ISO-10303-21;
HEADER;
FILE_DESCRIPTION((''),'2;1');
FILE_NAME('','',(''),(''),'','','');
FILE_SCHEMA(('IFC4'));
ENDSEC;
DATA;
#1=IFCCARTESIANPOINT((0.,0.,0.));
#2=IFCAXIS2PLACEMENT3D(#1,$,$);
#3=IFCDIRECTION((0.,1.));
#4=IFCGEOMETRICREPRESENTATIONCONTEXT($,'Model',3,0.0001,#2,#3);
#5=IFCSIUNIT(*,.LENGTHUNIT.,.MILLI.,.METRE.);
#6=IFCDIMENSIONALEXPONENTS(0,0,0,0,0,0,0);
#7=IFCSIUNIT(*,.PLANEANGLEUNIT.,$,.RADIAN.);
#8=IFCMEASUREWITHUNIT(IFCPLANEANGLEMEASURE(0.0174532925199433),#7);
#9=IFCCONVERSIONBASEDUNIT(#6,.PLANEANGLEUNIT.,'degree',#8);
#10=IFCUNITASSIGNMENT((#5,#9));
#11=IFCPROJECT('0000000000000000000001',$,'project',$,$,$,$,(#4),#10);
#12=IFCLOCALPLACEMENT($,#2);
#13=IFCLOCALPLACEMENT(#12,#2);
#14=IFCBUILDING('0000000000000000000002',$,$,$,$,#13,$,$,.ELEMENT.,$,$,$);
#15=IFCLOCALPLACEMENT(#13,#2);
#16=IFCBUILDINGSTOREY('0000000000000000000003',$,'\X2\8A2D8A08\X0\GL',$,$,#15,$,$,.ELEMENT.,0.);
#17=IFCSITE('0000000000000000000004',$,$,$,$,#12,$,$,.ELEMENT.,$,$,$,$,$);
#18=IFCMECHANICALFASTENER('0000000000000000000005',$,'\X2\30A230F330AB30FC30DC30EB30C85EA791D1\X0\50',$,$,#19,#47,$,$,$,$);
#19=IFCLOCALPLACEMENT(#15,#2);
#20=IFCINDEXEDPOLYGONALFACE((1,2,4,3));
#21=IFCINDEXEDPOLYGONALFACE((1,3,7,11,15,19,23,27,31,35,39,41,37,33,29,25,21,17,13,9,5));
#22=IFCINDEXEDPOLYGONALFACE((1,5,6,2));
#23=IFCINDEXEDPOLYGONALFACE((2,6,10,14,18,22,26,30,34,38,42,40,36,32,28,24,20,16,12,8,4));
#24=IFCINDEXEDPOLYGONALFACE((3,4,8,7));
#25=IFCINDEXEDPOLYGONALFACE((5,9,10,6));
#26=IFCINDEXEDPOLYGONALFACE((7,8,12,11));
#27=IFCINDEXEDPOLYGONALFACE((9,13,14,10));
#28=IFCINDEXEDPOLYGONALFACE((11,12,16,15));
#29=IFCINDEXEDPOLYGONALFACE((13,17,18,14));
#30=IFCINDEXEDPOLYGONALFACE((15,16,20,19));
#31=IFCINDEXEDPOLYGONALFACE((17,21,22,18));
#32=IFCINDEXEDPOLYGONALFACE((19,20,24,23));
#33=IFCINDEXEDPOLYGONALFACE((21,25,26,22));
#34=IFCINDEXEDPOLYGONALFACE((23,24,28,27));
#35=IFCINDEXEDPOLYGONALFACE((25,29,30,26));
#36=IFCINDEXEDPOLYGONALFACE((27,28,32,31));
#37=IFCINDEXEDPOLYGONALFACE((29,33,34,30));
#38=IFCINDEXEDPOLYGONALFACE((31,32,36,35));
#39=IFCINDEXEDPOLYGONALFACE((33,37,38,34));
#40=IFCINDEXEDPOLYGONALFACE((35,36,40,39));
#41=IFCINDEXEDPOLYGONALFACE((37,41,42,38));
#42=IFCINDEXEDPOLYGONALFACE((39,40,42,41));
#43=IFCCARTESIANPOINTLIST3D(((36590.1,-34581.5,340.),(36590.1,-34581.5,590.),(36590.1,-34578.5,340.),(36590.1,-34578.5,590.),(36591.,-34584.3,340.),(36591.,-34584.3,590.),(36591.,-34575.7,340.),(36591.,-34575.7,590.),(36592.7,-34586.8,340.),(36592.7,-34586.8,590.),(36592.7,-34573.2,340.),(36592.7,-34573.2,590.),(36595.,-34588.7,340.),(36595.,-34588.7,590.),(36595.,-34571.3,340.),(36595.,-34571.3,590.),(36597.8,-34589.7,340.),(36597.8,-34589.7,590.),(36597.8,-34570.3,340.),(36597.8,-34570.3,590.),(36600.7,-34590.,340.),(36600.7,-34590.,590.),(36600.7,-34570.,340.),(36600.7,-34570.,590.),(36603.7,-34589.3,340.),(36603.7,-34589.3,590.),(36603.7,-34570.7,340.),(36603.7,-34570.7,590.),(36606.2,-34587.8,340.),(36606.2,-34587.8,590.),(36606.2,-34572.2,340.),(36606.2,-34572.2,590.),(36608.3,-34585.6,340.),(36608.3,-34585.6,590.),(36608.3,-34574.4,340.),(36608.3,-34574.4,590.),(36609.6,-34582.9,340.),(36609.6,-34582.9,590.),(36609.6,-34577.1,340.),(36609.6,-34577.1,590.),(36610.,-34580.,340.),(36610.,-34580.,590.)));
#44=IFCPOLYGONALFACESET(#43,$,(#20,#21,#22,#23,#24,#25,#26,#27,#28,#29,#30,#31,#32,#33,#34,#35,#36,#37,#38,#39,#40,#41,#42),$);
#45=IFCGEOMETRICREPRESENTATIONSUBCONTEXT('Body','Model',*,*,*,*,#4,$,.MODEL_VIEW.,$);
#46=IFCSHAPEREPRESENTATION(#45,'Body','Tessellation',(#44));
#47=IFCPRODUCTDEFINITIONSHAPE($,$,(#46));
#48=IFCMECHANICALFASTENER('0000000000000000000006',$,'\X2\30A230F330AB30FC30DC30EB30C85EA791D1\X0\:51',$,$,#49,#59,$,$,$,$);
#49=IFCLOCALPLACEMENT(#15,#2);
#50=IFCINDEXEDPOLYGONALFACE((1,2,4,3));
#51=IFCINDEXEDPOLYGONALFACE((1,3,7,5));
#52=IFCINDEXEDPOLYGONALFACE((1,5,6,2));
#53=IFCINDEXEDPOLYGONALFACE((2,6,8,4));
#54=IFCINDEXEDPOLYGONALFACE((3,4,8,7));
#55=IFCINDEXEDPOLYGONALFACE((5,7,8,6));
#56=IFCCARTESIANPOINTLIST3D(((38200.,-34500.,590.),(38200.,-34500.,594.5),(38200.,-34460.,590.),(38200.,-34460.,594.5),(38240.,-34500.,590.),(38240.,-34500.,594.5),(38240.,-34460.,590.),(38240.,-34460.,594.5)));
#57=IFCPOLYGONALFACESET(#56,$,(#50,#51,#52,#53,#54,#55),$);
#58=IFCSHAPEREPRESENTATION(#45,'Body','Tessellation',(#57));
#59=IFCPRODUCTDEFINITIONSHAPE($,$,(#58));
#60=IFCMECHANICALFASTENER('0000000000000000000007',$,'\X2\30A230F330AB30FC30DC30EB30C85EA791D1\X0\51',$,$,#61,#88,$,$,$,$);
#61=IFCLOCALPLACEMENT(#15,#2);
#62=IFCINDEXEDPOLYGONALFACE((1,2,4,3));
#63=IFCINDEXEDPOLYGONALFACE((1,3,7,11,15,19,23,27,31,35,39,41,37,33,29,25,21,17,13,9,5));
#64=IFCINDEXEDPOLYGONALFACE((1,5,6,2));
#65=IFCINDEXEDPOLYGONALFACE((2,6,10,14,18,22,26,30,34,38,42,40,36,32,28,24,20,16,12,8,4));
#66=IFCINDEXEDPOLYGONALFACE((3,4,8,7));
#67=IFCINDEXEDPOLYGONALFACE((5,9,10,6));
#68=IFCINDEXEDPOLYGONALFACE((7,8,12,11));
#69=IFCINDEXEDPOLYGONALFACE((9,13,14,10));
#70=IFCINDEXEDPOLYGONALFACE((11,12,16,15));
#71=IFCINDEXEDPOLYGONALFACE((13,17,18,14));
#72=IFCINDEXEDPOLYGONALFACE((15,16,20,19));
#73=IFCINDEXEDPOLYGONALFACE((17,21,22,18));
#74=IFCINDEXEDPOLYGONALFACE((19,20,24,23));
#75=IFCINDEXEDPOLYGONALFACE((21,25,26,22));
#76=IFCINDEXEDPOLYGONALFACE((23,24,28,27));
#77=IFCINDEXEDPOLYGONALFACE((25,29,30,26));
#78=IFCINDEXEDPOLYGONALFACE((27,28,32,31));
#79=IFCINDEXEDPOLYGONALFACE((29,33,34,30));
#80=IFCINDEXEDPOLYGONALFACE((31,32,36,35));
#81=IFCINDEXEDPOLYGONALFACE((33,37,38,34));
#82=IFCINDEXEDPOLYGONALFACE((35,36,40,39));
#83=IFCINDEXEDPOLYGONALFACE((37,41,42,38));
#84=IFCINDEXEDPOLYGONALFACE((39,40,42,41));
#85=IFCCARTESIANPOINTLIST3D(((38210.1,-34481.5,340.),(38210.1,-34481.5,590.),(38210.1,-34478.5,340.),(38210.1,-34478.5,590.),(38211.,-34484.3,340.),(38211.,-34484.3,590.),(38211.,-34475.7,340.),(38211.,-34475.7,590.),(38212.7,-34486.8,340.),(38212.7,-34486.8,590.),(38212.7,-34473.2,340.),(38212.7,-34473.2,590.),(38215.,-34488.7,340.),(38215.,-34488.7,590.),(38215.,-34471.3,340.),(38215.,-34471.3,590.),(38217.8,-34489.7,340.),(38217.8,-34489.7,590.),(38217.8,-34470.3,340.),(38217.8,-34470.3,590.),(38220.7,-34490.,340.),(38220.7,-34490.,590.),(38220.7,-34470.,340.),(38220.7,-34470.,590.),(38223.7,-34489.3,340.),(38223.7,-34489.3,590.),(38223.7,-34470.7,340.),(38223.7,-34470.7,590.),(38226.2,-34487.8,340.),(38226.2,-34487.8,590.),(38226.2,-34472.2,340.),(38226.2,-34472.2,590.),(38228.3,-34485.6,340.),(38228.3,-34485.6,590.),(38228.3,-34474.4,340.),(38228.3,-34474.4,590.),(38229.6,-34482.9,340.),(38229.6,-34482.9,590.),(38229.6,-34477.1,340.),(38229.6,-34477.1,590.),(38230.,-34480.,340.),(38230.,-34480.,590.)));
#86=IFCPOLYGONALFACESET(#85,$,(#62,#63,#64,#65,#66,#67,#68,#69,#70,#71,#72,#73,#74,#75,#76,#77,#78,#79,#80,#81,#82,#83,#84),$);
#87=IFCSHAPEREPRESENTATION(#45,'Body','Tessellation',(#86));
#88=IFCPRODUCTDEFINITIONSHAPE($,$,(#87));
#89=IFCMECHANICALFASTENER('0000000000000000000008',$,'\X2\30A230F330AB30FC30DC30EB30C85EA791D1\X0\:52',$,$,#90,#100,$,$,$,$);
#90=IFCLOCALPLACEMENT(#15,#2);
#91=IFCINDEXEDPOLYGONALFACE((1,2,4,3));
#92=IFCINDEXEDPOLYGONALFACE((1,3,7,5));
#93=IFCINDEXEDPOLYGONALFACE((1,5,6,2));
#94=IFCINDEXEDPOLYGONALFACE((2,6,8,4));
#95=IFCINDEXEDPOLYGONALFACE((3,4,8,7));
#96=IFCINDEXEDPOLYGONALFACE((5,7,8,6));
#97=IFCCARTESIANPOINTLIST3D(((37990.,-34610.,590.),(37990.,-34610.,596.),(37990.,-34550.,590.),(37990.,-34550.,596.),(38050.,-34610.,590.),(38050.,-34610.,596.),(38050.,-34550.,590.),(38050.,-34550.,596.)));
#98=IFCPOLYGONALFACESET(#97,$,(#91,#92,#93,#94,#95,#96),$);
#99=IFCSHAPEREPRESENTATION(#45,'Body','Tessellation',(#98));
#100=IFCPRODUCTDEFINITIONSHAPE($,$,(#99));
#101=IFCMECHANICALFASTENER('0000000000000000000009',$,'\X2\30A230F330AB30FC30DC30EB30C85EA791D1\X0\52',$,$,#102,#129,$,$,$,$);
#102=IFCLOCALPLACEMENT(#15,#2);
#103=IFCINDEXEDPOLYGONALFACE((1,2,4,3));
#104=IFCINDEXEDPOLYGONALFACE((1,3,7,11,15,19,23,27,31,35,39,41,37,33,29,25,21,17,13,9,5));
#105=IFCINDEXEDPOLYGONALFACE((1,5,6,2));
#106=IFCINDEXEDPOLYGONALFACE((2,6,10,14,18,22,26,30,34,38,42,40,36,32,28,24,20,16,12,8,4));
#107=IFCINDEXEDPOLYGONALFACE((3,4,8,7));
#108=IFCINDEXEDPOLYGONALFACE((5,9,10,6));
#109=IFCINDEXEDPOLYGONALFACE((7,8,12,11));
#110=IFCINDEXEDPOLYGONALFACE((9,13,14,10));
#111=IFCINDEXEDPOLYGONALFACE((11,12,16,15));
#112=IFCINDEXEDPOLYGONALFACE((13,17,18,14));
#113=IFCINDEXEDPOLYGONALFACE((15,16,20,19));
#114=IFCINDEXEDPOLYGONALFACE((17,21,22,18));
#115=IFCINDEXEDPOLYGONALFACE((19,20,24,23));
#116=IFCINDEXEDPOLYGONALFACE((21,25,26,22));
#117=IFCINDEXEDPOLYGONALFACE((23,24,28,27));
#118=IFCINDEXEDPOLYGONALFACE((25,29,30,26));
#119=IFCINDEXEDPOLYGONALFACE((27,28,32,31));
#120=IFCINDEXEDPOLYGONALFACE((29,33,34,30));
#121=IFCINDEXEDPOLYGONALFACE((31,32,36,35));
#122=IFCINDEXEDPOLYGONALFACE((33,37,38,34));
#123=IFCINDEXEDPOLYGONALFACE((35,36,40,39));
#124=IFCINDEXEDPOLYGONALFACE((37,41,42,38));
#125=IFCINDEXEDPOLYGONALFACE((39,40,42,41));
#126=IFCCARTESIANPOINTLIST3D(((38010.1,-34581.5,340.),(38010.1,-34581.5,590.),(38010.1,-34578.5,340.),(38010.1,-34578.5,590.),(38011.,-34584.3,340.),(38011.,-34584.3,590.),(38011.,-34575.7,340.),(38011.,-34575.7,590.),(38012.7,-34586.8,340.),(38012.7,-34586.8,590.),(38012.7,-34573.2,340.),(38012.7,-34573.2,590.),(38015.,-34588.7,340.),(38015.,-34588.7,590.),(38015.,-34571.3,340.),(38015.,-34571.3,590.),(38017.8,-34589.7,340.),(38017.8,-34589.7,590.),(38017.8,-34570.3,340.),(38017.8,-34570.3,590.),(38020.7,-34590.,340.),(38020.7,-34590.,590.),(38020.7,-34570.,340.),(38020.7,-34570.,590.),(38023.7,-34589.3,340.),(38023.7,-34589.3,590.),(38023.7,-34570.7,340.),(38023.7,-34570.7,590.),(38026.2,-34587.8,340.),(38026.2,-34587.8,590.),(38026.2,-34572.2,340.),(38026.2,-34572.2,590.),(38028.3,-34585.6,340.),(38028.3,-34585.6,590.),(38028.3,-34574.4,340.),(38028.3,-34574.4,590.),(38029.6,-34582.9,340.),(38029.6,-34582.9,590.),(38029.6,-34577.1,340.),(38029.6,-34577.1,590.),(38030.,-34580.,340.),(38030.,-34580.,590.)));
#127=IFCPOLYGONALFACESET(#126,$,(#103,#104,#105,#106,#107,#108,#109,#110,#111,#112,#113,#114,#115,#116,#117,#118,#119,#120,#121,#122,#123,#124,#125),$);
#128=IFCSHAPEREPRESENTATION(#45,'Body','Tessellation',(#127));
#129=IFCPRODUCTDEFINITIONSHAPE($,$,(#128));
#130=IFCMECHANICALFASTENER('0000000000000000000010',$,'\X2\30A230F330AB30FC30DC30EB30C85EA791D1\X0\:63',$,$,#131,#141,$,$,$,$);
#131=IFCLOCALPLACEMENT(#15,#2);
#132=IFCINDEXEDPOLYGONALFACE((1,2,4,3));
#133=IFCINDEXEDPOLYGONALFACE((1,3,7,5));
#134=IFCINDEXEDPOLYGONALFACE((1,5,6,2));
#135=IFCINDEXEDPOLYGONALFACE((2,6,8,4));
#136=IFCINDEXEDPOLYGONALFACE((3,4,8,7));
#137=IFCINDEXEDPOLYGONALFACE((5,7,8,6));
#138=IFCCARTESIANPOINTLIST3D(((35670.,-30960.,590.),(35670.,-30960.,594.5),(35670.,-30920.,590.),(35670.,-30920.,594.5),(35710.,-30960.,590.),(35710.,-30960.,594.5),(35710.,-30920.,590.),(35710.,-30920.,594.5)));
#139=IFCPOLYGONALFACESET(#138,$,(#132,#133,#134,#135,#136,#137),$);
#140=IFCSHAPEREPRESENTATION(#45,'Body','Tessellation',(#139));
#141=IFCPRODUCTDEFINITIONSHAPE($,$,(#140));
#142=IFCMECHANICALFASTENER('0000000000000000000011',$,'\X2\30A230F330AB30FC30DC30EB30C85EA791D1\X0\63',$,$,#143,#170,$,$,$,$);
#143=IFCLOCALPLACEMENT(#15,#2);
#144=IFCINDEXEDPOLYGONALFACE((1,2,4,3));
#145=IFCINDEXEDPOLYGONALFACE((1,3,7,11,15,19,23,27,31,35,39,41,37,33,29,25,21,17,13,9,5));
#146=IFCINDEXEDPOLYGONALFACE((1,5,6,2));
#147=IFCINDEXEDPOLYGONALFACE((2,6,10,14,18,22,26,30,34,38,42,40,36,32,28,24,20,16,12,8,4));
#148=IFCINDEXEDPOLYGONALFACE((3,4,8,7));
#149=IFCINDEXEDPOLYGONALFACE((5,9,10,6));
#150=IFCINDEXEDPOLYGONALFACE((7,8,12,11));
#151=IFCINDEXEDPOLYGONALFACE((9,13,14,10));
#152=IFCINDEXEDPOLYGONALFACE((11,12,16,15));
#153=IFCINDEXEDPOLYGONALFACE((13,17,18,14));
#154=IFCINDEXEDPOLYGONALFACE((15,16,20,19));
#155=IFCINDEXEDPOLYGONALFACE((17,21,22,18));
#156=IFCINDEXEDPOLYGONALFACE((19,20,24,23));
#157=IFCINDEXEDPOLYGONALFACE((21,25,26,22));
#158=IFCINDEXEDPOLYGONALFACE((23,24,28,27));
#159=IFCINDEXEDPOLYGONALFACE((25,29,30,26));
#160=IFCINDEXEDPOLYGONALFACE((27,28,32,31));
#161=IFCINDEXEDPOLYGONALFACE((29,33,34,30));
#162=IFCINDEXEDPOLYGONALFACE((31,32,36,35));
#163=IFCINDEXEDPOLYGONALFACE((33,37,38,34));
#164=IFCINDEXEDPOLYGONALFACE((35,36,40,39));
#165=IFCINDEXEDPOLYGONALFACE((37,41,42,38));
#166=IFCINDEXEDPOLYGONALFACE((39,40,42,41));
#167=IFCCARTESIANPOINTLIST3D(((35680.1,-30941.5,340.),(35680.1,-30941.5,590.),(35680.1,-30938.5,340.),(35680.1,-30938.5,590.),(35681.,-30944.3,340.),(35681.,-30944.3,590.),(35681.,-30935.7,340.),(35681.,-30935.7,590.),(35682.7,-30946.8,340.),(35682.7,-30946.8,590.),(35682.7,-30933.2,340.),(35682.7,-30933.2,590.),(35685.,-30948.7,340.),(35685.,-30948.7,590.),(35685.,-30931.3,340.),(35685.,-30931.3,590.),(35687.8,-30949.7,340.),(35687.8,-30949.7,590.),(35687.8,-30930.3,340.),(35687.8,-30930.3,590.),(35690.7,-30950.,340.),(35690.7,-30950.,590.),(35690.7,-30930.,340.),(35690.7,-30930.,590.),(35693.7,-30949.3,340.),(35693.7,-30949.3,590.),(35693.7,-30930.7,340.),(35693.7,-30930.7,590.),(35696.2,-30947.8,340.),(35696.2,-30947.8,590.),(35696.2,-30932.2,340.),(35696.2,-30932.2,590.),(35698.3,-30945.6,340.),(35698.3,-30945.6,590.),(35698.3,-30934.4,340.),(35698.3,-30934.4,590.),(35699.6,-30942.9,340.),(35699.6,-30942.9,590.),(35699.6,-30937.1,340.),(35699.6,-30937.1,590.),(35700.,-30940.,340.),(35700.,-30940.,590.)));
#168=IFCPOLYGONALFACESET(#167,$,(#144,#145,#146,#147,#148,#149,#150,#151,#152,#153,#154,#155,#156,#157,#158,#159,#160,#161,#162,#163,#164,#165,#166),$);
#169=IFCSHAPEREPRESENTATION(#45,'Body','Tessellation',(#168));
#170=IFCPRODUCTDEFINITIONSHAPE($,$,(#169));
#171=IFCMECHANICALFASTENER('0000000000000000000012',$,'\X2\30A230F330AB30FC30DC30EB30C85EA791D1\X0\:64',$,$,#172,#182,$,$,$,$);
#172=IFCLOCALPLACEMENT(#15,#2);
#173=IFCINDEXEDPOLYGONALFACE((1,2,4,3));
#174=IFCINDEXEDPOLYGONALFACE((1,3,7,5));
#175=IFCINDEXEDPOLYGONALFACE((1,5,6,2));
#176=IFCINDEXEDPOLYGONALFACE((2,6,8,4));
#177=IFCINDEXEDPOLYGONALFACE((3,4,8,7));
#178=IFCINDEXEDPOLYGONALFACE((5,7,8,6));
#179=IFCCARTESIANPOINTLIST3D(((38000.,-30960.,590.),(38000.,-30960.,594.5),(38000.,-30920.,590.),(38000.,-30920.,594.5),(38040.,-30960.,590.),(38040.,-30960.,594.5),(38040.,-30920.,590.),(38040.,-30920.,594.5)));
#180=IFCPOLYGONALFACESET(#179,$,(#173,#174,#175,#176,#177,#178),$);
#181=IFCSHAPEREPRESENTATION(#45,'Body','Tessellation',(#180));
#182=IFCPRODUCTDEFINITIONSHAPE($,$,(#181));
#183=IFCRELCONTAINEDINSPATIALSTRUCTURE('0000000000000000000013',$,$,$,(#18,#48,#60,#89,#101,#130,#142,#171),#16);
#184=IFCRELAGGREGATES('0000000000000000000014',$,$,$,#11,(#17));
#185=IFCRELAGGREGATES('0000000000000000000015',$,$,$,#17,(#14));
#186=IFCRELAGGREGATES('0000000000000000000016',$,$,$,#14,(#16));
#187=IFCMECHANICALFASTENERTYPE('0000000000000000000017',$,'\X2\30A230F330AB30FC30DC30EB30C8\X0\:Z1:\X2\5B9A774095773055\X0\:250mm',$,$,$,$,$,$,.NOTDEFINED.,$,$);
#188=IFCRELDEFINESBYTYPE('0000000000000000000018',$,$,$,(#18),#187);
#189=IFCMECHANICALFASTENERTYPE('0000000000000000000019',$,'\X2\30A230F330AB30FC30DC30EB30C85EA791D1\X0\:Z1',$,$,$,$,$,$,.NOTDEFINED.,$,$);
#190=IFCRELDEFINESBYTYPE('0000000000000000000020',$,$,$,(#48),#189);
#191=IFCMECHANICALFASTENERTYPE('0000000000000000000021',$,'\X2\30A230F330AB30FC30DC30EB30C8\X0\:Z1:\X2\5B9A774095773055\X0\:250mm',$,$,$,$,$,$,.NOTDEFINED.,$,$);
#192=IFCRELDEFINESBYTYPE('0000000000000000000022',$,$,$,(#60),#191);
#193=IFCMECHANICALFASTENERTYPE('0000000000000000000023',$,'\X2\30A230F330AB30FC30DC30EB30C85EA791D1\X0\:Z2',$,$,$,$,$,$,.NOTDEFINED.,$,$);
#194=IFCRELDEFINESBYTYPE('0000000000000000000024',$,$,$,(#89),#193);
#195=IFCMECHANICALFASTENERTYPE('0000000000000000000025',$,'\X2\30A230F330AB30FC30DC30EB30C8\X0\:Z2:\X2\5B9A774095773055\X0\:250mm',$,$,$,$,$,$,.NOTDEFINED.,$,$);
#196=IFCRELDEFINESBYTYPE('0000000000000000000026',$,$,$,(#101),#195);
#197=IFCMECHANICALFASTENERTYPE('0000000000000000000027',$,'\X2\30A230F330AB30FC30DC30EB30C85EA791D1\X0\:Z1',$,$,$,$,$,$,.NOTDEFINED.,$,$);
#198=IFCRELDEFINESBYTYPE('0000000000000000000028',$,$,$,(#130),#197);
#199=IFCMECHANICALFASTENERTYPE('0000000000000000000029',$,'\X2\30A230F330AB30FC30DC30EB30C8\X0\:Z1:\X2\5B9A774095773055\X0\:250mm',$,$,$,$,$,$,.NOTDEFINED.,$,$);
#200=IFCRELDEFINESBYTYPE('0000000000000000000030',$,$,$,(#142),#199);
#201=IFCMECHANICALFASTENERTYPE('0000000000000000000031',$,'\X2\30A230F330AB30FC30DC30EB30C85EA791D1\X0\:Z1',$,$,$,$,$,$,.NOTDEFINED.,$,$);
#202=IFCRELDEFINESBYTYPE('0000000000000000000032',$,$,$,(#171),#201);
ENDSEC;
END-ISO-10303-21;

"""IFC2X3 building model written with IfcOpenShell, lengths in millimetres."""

from ifc_helpers import new_model, entity, si_unit, converted_unit, direction, frame, origin, origin_with_axes, origin_2d, place, context, subcontext, project, spatial, rectangle, circle, extrude, type_object, element, save


model = new_model("IFC2X3")

# Units and contexts
model_context = context("Model", 3, precision=0.0001, world=origin(), true_north=direction((0.0, 1.0)))
body_context = subcontext(model_context, "Body", "Model", "MODEL_VIEW")
ifc_project = project(units=[si_unit("LENGTHUNIT", "METRE", prefix="MILLI"), converted_unit("PLANEANGLEUNIT", "degree", entity("IfcPlaneAngleMeasure", 0.0174532925199433), si_unit("PLANEANGLEUNIT", "RADIAN"), dimensions=[0, 0, 0, 0, 0, 0, 0])], contexts=[model_context])

# Site, building, storey
site_placement = place(None, origin())
site = spatial("IfcSite", under=ifc_project, at=site_placement, CompositionType="ELEMENT")
building_placement = place(site_placement, origin())
building = spatial("IfcBuilding", under=site, at=building_placement, CompositionType="ELEMENT")
storey_placement = place(building_placement, origin())
storey = spatial("IfcBuildingStorey", under=building, at=storey_placement, Name="設計GL", CompositionType="ELEMENT", Elevation=0.0)

# Mechanical fasteners
mechanical_fastener_type_1 = type_object("IfcMechanicalFastenerType", Name="アンカーボルト:Z1:定着長さ:250mm")
mechanical_fastener_1_placement = place(storey_placement, frame((36600.0, -34580.0, 340.0)))
element("IfcMechanicalFastener", 1, at=mechanical_fastener_1_placement, inside=storey, type_object=mechanical_fastener_type_1, Name="アンカーボルト座金50", context=body_context, shape_type="SweptSolid", body=[
    extrude(circle(Radius=10.0, at=origin_2d()), origin_with_axes(), (0.0, 0.0, 1.0), 250.0),
])
mechanical_fastener_type_2 = type_object("IfcMechanicalFastenerType", Name="アンカーボルト座金:Z1")
mechanical_fastener_2_placement = place(storey_placement, frame((38220.0, -34480.0, 590.0)))
element("IfcMechanicalFastener", 2, at=mechanical_fastener_2_placement, inside=storey, type_object=mechanical_fastener_type_2, Name="アンカーボルト座金:51", context=body_context, shape_type="SweptSolid", body=[
    extrude(rectangle(XDim=40.0, YDim=40.0, at=origin_2d()), origin_with_axes(), (0.0, 0.0, 1.0), 4.5),
])
mechanical_fastener_type_3 = type_object("IfcMechanicalFastenerType", Name="アンカーボルト:Z1:定着長さ:250mm")
mechanical_fastener_3_placement = place(storey_placement, frame((38220.0, -34480.0, 340.0)))
element("IfcMechanicalFastener", 3, at=mechanical_fastener_3_placement, inside=storey, type_object=mechanical_fastener_type_3, Name="アンカーボルト座金51", context=body_context, shape_type="SweptSolid", body=[
    extrude(circle(Radius=10.0, at=origin_2d()), origin_with_axes(), (0.0, 0.0, 1.0), 250.0),
])
mechanical_fastener_type_4 = type_object("IfcMechanicalFastenerType", Name="アンカーボルト座金:Z2")
mechanical_fastener_4_placement = place(storey_placement, frame((38020.0, -34580.0, 590.0)))
element("IfcMechanicalFastener", 4, at=mechanical_fastener_4_placement, inside=storey, type_object=mechanical_fastener_type_4, Name="アンカーボルト座金:52", context=body_context, shape_type="SweptSolid", body=[
    extrude(rectangle(XDim=60.0, YDim=60.0, at=origin_2d()), origin_with_axes(), (0.0, 0.0, 1.0), 6.0),
])
mechanical_fastener_type_5 = type_object("IfcMechanicalFastenerType", Name="アンカーボルト:Z2:定着長さ:250mm")
mechanical_fastener_5_placement = place(storey_placement, frame((38020.0, -34580.0, 340.0)))
element("IfcMechanicalFastener", 5, at=mechanical_fastener_5_placement, inside=storey, type_object=mechanical_fastener_type_5, Name="アンカーボルト座金52", context=body_context, shape_type="SweptSolid", body=[
    extrude(circle(Radius=10.0, at=origin_2d()), origin_with_axes(), (0.0, 0.0, 1.0), 250.0),
])
mechanical_fastener_type_6 = type_object("IfcMechanicalFastenerType", Name="アンカーボルト座金:Z1")
mechanical_fastener_6_placement = place(storey_placement, frame((35690.0, -30940.0, 590.0)))
element("IfcMechanicalFastener", 6, at=mechanical_fastener_6_placement, inside=storey, type_object=mechanical_fastener_type_6, Name="アンカーボルト座金:63", context=body_context, shape_type="SweptSolid", body=[
    extrude(rectangle(XDim=40.0, YDim=40.0, at=origin_2d()), origin_with_axes(), (0.0, 0.0, 1.0), 4.5),
])
mechanical_fastener_type_7 = type_object("IfcMechanicalFastenerType", Name="アンカーボルト:Z1:定着長さ:250mm")
mechanical_fastener_7_placement = place(storey_placement, frame((35690.0, -30940.0, 340.0)))
element("IfcMechanicalFastener", 7, at=mechanical_fastener_7_placement, inside=storey, type_object=mechanical_fastener_type_7, Name="アンカーボルト座金63", context=body_context, shape_type="SweptSolid", body=[
    extrude(circle(Radius=10.0, at=origin_2d()), origin_with_axes(), (0.0, 0.0, 1.0), 250.0),
])
mechanical_fastener_type_8 = type_object("IfcMechanicalFastenerType", Name="アンカーボルト座金:Z1")
mechanical_fastener_8_placement = place(storey_placement, frame((38020.0, -30940.0, 590.0)))
element("IfcMechanicalFastener", 8, at=mechanical_fastener_8_placement, inside=storey, type_object=mechanical_fastener_type_8, Name="アンカーボルト座金:64", context=body_context, shape_type="SweptSolid", body=[
    extrude(rectangle(XDim=40.0, YDim=40.0, at=origin_2d()), origin_with_axes(), (0.0, 0.0, 1.0), 4.5),
])

save(model, "model.ifc")
